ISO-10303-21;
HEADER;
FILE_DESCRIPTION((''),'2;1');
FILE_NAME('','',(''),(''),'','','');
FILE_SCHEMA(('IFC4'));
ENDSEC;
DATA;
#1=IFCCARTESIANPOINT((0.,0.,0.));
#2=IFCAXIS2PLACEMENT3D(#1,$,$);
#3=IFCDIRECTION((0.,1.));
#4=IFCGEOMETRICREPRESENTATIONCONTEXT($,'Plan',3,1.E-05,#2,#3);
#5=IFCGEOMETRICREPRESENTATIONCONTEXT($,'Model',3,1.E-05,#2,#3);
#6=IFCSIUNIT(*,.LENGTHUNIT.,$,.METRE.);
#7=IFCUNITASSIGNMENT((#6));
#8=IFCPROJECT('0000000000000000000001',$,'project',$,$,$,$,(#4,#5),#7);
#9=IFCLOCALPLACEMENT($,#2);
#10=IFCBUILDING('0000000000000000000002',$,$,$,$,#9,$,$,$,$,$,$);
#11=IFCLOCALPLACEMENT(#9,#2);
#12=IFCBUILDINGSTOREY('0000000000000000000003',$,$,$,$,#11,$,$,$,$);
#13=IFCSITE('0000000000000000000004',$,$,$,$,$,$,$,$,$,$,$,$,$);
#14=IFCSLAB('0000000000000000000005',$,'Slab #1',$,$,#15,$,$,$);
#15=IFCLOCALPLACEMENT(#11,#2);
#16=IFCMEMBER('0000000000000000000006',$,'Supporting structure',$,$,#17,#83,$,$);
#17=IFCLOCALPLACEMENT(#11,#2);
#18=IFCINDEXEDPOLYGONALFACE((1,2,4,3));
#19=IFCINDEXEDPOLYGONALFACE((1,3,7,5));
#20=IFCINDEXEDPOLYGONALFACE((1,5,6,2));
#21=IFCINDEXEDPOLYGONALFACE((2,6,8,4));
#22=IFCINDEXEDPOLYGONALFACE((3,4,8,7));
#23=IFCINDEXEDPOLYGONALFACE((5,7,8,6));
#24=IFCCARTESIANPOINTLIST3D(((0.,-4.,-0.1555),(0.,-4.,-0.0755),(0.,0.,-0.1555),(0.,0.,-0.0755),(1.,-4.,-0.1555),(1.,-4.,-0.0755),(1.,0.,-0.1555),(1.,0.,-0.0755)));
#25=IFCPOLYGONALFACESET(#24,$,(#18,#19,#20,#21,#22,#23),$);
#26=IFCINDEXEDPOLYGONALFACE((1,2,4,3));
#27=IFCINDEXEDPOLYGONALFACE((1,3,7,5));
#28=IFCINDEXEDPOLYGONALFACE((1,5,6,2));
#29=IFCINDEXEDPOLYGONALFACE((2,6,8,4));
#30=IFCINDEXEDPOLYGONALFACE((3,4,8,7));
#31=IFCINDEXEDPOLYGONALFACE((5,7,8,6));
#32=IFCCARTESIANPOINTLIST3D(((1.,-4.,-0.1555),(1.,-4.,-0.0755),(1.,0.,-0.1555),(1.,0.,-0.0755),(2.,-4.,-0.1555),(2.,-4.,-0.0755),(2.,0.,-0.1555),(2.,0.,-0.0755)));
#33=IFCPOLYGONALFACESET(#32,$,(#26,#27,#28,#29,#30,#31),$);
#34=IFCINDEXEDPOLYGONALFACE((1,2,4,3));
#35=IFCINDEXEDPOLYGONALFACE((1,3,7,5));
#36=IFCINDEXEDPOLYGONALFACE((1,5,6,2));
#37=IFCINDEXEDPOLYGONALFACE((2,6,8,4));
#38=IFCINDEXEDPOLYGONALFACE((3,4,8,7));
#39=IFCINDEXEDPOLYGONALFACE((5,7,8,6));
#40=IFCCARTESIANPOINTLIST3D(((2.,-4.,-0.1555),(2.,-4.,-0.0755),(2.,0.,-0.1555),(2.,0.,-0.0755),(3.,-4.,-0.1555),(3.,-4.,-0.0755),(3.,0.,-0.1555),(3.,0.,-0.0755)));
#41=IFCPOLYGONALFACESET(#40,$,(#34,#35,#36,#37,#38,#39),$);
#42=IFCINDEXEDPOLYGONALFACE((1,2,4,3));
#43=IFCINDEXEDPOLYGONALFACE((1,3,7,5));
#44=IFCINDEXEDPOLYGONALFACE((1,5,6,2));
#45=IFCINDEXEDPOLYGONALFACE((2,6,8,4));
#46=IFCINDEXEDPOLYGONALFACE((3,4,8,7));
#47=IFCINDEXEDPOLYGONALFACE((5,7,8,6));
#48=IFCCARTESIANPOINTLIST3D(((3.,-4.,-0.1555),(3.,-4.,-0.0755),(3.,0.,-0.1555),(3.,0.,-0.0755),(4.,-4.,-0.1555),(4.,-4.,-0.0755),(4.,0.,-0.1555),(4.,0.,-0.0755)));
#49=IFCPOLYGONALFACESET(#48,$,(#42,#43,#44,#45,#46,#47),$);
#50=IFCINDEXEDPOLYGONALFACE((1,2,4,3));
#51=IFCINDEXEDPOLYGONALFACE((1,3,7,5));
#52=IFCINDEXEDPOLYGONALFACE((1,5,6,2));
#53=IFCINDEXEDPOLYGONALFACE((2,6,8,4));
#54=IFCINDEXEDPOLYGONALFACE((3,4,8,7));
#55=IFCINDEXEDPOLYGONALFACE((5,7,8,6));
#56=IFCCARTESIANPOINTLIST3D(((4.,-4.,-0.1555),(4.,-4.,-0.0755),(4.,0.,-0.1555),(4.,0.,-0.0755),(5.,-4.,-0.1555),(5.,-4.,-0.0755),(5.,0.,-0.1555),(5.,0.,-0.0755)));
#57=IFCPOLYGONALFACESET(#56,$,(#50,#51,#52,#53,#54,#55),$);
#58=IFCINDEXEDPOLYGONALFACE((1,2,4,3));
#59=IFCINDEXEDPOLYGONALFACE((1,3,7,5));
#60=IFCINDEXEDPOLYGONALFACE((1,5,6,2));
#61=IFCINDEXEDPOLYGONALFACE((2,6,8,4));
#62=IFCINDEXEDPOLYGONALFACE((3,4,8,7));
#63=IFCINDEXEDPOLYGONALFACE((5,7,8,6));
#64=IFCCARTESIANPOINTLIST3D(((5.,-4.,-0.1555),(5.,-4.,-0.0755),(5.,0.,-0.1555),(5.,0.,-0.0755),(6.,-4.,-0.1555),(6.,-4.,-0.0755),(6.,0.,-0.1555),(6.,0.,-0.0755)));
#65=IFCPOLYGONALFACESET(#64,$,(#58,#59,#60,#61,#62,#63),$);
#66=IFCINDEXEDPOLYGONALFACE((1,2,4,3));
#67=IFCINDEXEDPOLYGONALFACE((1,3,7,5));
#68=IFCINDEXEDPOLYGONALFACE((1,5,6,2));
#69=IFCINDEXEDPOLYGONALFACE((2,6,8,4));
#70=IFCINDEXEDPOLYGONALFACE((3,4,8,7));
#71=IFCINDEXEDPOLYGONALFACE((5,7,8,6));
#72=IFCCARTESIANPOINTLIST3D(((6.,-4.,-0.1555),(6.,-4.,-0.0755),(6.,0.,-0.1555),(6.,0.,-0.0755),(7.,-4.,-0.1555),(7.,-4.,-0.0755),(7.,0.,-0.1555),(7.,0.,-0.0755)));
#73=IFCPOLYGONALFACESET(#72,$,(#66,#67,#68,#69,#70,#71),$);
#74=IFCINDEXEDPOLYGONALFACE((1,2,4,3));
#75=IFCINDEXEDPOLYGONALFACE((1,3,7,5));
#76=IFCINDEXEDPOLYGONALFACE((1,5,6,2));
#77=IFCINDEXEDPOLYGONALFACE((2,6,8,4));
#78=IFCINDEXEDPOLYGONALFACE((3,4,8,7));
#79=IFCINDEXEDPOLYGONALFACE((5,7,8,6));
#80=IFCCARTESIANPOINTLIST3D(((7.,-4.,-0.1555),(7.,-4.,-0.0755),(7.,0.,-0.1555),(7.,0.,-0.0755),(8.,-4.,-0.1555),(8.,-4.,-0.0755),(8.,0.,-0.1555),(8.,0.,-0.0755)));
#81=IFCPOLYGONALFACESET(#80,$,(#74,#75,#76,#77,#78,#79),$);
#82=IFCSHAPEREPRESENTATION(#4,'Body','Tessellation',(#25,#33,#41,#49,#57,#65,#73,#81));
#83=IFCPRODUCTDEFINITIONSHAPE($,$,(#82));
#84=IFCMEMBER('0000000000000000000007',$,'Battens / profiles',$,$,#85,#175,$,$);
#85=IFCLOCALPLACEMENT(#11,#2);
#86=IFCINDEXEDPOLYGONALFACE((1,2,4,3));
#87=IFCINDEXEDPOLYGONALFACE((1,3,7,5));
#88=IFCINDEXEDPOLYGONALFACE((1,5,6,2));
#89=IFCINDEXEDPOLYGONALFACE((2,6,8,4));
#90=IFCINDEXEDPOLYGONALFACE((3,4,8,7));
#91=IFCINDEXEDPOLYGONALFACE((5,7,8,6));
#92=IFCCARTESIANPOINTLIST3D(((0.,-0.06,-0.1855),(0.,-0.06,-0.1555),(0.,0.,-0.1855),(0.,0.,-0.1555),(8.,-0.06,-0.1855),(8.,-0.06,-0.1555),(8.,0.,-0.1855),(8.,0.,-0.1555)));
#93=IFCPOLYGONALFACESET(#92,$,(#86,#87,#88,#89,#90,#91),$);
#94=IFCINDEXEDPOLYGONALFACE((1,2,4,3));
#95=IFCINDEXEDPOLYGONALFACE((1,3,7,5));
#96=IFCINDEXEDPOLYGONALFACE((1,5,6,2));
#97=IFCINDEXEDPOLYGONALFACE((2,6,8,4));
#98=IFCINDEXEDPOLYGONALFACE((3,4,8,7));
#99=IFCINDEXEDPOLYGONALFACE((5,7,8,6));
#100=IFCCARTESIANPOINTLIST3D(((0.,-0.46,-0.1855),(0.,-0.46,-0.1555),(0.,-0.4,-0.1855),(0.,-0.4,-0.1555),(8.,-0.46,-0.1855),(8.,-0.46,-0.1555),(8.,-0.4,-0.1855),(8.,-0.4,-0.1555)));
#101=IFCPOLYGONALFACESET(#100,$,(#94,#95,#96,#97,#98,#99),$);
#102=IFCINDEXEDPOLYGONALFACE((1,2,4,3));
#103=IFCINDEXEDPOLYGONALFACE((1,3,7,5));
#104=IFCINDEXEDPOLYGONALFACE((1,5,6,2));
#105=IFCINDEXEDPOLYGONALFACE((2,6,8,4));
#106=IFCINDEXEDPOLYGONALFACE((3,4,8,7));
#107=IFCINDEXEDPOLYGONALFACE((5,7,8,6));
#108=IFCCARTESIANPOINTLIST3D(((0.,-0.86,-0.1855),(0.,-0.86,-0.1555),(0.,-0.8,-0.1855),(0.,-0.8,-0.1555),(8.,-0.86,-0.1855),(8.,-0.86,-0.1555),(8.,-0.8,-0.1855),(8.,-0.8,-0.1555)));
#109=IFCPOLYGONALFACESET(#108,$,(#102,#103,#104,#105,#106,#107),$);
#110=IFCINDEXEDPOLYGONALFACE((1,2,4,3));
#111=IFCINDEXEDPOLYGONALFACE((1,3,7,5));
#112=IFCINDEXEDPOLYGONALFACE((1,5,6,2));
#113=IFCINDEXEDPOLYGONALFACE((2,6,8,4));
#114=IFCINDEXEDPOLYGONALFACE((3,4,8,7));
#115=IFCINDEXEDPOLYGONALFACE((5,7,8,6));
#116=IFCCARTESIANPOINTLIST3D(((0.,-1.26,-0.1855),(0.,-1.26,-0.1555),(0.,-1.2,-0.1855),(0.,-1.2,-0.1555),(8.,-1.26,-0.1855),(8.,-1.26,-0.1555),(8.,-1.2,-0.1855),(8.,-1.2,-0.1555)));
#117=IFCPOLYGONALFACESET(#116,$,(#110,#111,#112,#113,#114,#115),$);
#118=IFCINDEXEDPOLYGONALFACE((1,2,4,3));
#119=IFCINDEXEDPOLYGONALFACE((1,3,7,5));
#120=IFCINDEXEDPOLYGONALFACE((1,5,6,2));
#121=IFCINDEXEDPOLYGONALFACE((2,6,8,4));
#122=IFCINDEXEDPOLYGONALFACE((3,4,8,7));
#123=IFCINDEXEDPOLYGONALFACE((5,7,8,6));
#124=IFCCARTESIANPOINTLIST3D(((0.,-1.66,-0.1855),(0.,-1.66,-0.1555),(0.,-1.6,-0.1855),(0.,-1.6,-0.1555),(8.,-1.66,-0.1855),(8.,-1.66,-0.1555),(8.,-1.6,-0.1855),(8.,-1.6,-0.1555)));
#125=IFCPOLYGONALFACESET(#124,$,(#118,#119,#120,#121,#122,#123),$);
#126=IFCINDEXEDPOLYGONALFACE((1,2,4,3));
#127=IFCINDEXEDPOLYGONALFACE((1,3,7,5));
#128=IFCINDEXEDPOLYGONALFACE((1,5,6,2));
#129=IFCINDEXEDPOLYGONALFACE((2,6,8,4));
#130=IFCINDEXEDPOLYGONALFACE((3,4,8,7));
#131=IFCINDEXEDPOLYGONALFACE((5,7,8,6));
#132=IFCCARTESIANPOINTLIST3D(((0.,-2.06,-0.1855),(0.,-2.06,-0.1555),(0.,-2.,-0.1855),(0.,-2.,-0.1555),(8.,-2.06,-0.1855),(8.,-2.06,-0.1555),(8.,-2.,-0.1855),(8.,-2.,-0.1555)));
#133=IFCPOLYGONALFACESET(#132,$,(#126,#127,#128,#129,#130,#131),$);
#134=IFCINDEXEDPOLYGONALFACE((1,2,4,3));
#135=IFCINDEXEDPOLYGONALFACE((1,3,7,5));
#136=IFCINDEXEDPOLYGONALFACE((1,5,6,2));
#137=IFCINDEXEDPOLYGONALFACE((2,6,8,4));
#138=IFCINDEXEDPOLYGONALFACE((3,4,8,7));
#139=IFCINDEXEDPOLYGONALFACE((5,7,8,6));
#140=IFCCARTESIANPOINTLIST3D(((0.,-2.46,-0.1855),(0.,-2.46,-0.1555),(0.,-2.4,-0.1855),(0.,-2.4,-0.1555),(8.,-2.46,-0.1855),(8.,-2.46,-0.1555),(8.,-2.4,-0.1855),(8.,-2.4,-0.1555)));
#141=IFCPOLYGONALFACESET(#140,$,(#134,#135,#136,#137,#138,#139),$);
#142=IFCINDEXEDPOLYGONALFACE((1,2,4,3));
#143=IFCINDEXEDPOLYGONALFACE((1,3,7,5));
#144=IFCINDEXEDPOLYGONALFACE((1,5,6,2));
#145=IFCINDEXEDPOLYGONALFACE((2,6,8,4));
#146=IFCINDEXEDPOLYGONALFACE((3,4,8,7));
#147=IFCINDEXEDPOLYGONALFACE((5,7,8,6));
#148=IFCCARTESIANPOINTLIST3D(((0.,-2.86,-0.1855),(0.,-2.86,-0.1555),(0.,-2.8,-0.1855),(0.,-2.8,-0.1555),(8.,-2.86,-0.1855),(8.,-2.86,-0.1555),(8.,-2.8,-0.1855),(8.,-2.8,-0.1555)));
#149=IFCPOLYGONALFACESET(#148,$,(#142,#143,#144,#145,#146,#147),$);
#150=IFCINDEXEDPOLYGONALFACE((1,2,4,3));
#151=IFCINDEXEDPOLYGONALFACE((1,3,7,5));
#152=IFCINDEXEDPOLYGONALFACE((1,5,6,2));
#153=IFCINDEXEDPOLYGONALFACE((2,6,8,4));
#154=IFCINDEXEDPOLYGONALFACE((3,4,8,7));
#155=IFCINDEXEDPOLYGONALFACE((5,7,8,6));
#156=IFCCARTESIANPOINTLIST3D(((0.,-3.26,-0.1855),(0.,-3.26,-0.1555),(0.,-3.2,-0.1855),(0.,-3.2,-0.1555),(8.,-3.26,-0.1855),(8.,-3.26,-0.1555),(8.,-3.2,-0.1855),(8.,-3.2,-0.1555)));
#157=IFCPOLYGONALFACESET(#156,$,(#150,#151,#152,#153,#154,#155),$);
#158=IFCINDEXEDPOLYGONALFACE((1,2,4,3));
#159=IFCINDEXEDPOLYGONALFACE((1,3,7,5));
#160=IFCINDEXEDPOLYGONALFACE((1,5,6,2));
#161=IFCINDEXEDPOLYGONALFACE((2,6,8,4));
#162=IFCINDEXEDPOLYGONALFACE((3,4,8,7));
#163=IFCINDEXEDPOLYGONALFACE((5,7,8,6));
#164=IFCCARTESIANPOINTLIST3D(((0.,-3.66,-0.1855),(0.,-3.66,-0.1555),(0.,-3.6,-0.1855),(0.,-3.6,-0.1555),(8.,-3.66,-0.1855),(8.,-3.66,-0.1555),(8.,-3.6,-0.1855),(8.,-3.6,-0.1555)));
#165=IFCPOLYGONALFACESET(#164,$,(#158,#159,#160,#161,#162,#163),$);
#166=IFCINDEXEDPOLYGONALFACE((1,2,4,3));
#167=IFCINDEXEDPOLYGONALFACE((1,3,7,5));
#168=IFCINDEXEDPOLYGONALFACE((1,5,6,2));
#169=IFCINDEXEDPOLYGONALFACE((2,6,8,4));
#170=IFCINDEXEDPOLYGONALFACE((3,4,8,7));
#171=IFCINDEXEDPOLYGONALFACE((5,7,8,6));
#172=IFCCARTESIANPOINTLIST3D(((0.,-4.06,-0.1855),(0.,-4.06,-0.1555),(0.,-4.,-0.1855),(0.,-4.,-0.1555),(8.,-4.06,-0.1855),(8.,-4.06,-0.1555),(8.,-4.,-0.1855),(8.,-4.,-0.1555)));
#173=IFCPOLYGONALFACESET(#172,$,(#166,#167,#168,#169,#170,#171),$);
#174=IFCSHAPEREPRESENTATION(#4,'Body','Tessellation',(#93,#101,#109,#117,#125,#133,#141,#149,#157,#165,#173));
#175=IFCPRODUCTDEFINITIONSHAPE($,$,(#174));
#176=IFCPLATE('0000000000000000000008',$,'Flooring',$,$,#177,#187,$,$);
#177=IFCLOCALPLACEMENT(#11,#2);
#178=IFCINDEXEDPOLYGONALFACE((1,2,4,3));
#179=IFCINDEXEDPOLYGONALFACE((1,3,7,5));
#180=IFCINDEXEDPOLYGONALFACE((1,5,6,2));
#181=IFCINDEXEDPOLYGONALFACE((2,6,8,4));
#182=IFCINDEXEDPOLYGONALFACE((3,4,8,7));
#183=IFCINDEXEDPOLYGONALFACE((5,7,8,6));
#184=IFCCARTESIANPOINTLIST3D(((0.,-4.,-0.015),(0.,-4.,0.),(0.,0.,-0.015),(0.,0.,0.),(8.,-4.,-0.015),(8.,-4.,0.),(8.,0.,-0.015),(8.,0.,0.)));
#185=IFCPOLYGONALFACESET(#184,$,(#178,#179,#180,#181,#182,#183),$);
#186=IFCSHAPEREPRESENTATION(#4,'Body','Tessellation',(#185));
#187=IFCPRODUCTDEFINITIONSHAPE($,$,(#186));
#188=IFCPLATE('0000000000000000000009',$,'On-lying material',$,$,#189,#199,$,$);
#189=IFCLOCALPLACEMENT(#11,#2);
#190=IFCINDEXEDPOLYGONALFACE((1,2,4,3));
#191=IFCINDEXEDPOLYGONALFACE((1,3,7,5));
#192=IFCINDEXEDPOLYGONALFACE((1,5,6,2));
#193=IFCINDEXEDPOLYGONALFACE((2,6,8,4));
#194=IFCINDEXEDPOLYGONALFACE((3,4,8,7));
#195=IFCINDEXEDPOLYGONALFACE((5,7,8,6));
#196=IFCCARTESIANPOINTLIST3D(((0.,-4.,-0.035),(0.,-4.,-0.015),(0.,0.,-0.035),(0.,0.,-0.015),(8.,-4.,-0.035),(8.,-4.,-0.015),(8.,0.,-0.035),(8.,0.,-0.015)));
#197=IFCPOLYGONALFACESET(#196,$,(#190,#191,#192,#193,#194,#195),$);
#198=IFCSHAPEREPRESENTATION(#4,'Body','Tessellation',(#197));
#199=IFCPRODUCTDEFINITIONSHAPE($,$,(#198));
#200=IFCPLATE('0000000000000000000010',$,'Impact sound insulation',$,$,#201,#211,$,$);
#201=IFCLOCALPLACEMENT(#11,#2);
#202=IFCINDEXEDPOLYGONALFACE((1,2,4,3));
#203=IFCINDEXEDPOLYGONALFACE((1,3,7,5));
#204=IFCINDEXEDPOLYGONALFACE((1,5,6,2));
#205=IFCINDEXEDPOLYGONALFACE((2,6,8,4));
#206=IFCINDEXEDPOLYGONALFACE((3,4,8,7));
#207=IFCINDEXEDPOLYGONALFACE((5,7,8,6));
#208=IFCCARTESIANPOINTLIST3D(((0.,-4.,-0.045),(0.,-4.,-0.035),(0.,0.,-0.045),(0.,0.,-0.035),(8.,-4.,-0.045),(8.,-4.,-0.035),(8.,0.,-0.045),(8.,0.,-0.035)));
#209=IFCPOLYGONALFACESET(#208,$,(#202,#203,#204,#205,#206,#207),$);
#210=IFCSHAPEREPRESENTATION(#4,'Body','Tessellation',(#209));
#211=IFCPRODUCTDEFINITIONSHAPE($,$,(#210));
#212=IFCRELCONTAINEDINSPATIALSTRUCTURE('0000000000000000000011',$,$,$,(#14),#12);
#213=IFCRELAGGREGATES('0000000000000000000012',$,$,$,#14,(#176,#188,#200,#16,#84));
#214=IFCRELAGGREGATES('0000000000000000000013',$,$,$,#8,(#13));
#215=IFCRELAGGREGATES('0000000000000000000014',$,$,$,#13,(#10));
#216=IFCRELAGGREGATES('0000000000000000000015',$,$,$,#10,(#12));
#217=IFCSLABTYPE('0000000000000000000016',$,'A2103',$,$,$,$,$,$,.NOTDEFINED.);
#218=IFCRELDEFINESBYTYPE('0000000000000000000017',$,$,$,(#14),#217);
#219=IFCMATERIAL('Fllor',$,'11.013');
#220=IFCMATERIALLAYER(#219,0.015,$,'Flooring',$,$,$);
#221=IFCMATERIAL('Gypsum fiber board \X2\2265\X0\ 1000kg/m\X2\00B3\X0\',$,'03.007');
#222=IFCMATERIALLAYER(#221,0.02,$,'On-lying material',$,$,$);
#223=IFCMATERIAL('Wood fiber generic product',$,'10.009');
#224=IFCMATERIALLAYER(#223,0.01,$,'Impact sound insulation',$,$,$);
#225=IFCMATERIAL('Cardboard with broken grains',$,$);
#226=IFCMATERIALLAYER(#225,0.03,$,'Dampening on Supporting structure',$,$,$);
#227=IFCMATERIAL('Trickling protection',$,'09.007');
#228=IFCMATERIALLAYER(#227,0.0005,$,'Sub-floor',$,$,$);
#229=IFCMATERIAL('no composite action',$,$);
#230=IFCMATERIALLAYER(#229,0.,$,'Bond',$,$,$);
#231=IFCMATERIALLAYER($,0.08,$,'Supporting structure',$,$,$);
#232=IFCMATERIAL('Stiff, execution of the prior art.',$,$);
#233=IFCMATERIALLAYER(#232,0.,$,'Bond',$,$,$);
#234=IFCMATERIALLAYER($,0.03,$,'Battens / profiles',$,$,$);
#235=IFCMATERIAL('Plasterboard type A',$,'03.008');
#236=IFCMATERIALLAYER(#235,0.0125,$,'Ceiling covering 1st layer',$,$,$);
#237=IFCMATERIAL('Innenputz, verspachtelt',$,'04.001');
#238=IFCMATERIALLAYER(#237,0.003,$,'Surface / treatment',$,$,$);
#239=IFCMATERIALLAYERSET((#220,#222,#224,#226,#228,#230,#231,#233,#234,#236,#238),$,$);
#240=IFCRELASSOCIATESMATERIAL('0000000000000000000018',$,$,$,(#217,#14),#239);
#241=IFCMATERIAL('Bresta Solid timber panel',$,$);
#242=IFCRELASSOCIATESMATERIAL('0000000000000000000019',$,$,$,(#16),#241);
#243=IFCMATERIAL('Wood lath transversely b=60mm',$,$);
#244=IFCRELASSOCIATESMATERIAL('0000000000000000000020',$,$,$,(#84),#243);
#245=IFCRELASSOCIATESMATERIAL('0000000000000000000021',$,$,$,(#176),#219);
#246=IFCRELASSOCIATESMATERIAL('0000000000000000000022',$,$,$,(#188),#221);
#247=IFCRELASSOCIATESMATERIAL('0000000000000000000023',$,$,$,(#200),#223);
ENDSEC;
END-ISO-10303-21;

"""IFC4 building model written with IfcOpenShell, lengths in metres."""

from ifc_helpers import new_model, si_unit, direction, frame, frame_2d, origin, origin_with_axes, place, context, project, spatial, rectangle, extrude, material, layer, layer_set, type_object, element, aggregate, save


model = new_model("IFC4")

# Units and contexts
plan_context = context("Plan", 3, precision=1e-05, world=origin(), true_north=direction((0.0, 1.0)))
model_context = context("Model", 3, precision=1e-05, world=origin(), true_north=direction((0.0, 1.0)))
ifc_project = project(units=[si_unit("LENGTHUNIT", "METRE")], contexts=[plan_context, model_context])

# Site, building, storey
site = spatial("IfcSite", under=ifc_project)
building_placement = place(None, origin())
building = spatial("IfcBuilding", under=site, at=building_placement)
storey_placement = place(building_placement, origin())
storey = spatial("IfcBuildingStorey", under=building, at=storey_placement)

# Slab, members, plates
ifc_material_1 = material(Name="Fllor", Category="11.013")
ifc_layer_1 = layer(ifc_material_1, 0.015, Name="Flooring")
ifc_material_2 = material(Name="Gypsum fiber board ≥ 1000kg/m³", Category="03.007")
ifc_layer_2 = layer(ifc_material_2, 0.02, Name="On-lying material")
ifc_material_3 = material(Name="Wood fiber generic product", Category="10.009")
ifc_layer_3 = layer(ifc_material_3, 0.01, Name="Impact sound insulation")
ifc_material_4 = material(Name="Cardboard with broken grains")
ifc_layer_4 = layer(ifc_material_4, 0.03, Name="Dampening on Supporting structure")
ifc_material_5 = material(Name="Trickling protection", Category="09.007")
ifc_layer_5 = layer(ifc_material_5, 0.0005, Name="Sub-floor")
ifc_material_6 = material(Name="no composite action")
ifc_layer_6 = layer(ifc_material_6, 0.0, Name="Bond")
ifc_layer_7 = layer(None, 0.08, Name="Supporting structure")
ifc_material_7 = material(Name="Stiff, execution of the prior art.")
ifc_layer_8 = layer(ifc_material_7, 0.0, Name="Bond")
ifc_layer_9 = layer(None, 0.03, Name="Battens / profiles")
ifc_material_8 = material(Name="Plasterboard type A", Category="03.008")
ifc_layer_10 = layer(ifc_material_8, 0.0125, Name="Ceiling covering 1st layer")
ifc_material_9 = material(Name="Innenputz, verspachtelt", Category="04.001")
ifc_layer_11 = layer(ifc_material_9, 0.003, Name="Surface / treatment")
ifc_layer_set = layer_set([ifc_layer_1, ifc_layer_2, ifc_layer_3, ifc_layer_4, ifc_layer_5, ifc_layer_6, ifc_layer_7, ifc_layer_8, ifc_layer_9, ifc_layer_10, ifc_layer_11])
slab_type = type_object("IfcSlabType", Name="A2103", PredefinedType="NOTDEFINED", material=ifc_layer_set)
slab_placement = place(None, frame((0.0, 0.0, 0.0), z_axis=(0.0, 0.0, -1.0), x_axis=(1.0, 0.0, 0.0)))
slab = element("IfcSlab", 1, at=slab_placement, inside=storey, type_object=slab_type, material=ifc_layer_set, Name="Slab #1")
ifc_material_10 = material(Name="Bresta Solid timber panel")
member_1_placement = place(slab_placement, origin())
member_1 = element("IfcMember", 2, at=member_1_placement, material=ifc_material_10, Name="Supporting structure", context=plan_context, shape_type="SweptSolid", body=[
    extrude(rectangle(XDim=1.0, YDim=0.08, at=frame_2d((0.5, 0.04), x_axis=(1.0, 0.0))), frame((0.0, 4.0, 0.0755), z_axis=(0.0, -1.0, 0.0), x_axis=(1.0, 0.0, 0.0)), (0.0, 0.0, 1.0), 4.0),
    extrude(rectangle(XDim=1.0, YDim=0.08, at=frame_2d((0.5, 0.04), x_axis=(1.0, 0.0))), frame((1.0, 4.0, 0.0755), z_axis=(0.0, -1.0, 0.0), x_axis=(1.0, 0.0, 0.0)), (0.0, 0.0, 1.0), 4.0),
    extrude(rectangle(XDim=1.0, YDim=0.08, at=frame_2d((0.5, 0.04), x_axis=(1.0, 0.0))), frame((2.0, 4.0, 0.0755), z_axis=(0.0, -1.0, 0.0), x_axis=(1.0, 0.0, 0.0)), (0.0, 0.0, 1.0), 4.0),
    extrude(rectangle(XDim=1.0, YDim=0.08, at=frame_2d((0.5, 0.04), x_axis=(1.0, 0.0))), frame((3.0, 4.0, 0.0755), z_axis=(0.0, -1.0, 0.0), x_axis=(1.0, 0.0, 0.0)), (0.0, 0.0, 1.0), 4.0),
    extrude(rectangle(XDim=1.0, YDim=0.08, at=frame_2d((0.5, 0.04), x_axis=(1.0, 0.0))), frame((4.0, 4.0, 0.0755), z_axis=(0.0, -1.0, 0.0), x_axis=(1.0, 0.0, 0.0)), (0.0, 0.0, 1.0), 4.0),
    extrude(rectangle(XDim=1.0, YDim=0.08, at=frame_2d((0.5, 0.04), x_axis=(1.0, 0.0))), frame((5.0, 4.0, 0.0755), z_axis=(0.0, -1.0, 0.0), x_axis=(1.0, 0.0, 0.0)), (0.0, 0.0, 1.0), 4.0),
    extrude(rectangle(XDim=1.0, YDim=0.08, at=frame_2d((0.5, 0.04), x_axis=(1.0, 0.0))), frame((6.0, 4.0, 0.0755), z_axis=(0.0, -1.0, 0.0), x_axis=(1.0, 0.0, 0.0)), (0.0, 0.0, 1.0), 4.0),
    extrude(rectangle(XDim=1.0, YDim=0.08, at=frame_2d((0.5, 0.04), x_axis=(1.0, 0.0))), frame((7.0, 4.0, 0.0755), z_axis=(0.0, -1.0, 0.0), x_axis=(1.0, 0.0, 0.0)), (0.0, 0.0, 1.0), 4.0),
])
ifc_material_11 = material(Name="Wood lath transversely b=60mm")
member_2_placement = place(slab_placement, origin())
member_2 = element("IfcMember", 3, at=member_2_placement, material=ifc_material_11, Name="Battens / profiles", context=plan_context, shape_type="SweptSolid", body=[
    extrude(rectangle(XDim=0.06, YDim=0.03, at=frame_2d((0.03, 0.015), x_axis=(1.0, 0.0))), frame((0.0, 0.0, 0.1555), z_axis=(1.0, 0.0, 0.0), x_axis=(0.0, 1.0, 0.0)), (0.0, 0.0, 1.0), 8.0),
    extrude(rectangle(XDim=0.06, YDim=0.03, at=frame_2d((0.03, 0.015), x_axis=(1.0, 0.0))), frame((0.0, 0.4, 0.1555), z_axis=(1.0, 0.0, 0.0), x_axis=(0.0, 1.0, 0.0)), (0.0, 0.0, 1.0), 8.0),
    extrude(rectangle(XDim=0.06, YDim=0.03, at=frame_2d((0.03, 0.015), x_axis=(1.0, 0.0))), frame((0.0, 0.8, 0.1555), z_axis=(1.0, 0.0, 0.0), x_axis=(0.0, 1.0, 0.0)), (0.0, 0.0, 1.0), 8.0),
    extrude(rectangle(XDim=0.06, YDim=0.03, at=frame_2d((0.03, 0.015), x_axis=(1.0, 0.0))), frame((0.0, 1.2, 0.1555), z_axis=(1.0, 0.0, 0.0), x_axis=(0.0, 1.0, 0.0)), (0.0, 0.0, 1.0), 8.0),
    extrude(rectangle(XDim=0.06, YDim=0.03, at=frame_2d((0.03, 0.015), x_axis=(1.0, 0.0))), frame((0.0, 1.6, 0.1555), z_axis=(1.0, 0.0, 0.0), x_axis=(0.0, 1.0, 0.0)), (0.0, 0.0, 1.0), 8.0),
    extrude(rectangle(XDim=0.06, YDim=0.03, at=frame_2d((0.03, 0.015), x_axis=(1.0, 0.0))), frame((0.0, 2.0, 0.1555), z_axis=(1.0, 0.0, 0.0), x_axis=(0.0, 1.0, 0.0)), (0.0, 0.0, 1.0), 8.0),
    extrude(rectangle(XDim=0.06, YDim=0.03, at=frame_2d((0.03, 0.015), x_axis=(1.0, 0.0))), frame((0.0, 2.4, 0.1555), z_axis=(1.0, 0.0, 0.0), x_axis=(0.0, 1.0, 0.0)), (0.0, 0.0, 1.0), 8.0),
    extrude(rectangle(XDim=0.06, YDim=0.03, at=frame_2d((0.03, 0.015), x_axis=(1.0, 0.0))), frame((0.0, 2.8, 0.1555), z_axis=(1.0, 0.0, 0.0), x_axis=(0.0, 1.0, 0.0)), (0.0, 0.0, 1.0), 8.0),
    extrude(rectangle(XDim=0.06, YDim=0.03, at=frame_2d((0.03, 0.015), x_axis=(1.0, 0.0))), frame((0.0, 3.2, 0.1555), z_axis=(1.0, 0.0, 0.0), x_axis=(0.0, 1.0, 0.0)), (0.0, 0.0, 1.0), 8.0),
    extrude(rectangle(XDim=0.06, YDim=0.03, at=frame_2d((0.03, 0.015), x_axis=(1.0, 0.0))), frame((0.0, 3.6, 0.1555), z_axis=(1.0, 0.0, 0.0), x_axis=(0.0, 1.0, 0.0)), (0.0, 0.0, 1.0), 8.0),
    extrude(rectangle(XDim=0.06, YDim=0.03, at=frame_2d((0.03, 0.015), x_axis=(1.0, 0.0))), frame((0.0, 4.0, 0.1555), z_axis=(1.0, 0.0, 0.0), x_axis=(0.0, 1.0, 0.0)), (0.0, 0.0, 1.0), 8.0),
])
plate_1_placement = place(slab_placement, origin())
plate_1 = element("IfcPlate", 4, at=plate_1_placement, material=ifc_material_1, Name="Flooring", context=plan_context, shape_type="SweptSolid", body=[
    extrude(rectangle(XDim=8.0, YDim=4.0, at=frame_2d((4.0, 2.0), x_axis=(1.0, 0.0))), origin_with_axes(), (0.0, 0.0, 1.0), 0.015),
])
plate_2_placement = place(slab_placement, origin())
plate_2 = element("IfcPlate", 5, at=plate_2_placement, material=ifc_material_2, Name="On-lying material", context=plan_context, shape_type="SweptSolid", body=[
    extrude(rectangle(XDim=8.0, YDim=4.0, at=frame_2d((4.0, 2.0), x_axis=(1.0, 0.0))), frame((0.0, 0.0, 0.015), z_axis=(0.0, 0.0, 1.0), x_axis=(1.0, 0.0, 0.0)), (0.0, 0.0, 1.0), 0.02),
])
plate_3_placement = place(slab_placement, origin())
plate_3 = element("IfcPlate", 6, at=plate_3_placement, material=ifc_material_3, Name="Impact sound insulation", context=plan_context, shape_type="SweptSolid", body=[
    extrude(rectangle(XDim=8.0, YDim=4.0, at=frame_2d((4.0, 2.0), x_axis=(1.0, 0.0))), frame((0.0, 0.0, 0.035), z_axis=(0.0, 0.0, 1.0), x_axis=(1.0, 0.0, 0.0)), (0.0, 0.0, 1.0), 0.01),
])
aggregate(slab, [plate_1, plate_2, plate_3, member_1, member_2])

save(model, "model.ifc")
